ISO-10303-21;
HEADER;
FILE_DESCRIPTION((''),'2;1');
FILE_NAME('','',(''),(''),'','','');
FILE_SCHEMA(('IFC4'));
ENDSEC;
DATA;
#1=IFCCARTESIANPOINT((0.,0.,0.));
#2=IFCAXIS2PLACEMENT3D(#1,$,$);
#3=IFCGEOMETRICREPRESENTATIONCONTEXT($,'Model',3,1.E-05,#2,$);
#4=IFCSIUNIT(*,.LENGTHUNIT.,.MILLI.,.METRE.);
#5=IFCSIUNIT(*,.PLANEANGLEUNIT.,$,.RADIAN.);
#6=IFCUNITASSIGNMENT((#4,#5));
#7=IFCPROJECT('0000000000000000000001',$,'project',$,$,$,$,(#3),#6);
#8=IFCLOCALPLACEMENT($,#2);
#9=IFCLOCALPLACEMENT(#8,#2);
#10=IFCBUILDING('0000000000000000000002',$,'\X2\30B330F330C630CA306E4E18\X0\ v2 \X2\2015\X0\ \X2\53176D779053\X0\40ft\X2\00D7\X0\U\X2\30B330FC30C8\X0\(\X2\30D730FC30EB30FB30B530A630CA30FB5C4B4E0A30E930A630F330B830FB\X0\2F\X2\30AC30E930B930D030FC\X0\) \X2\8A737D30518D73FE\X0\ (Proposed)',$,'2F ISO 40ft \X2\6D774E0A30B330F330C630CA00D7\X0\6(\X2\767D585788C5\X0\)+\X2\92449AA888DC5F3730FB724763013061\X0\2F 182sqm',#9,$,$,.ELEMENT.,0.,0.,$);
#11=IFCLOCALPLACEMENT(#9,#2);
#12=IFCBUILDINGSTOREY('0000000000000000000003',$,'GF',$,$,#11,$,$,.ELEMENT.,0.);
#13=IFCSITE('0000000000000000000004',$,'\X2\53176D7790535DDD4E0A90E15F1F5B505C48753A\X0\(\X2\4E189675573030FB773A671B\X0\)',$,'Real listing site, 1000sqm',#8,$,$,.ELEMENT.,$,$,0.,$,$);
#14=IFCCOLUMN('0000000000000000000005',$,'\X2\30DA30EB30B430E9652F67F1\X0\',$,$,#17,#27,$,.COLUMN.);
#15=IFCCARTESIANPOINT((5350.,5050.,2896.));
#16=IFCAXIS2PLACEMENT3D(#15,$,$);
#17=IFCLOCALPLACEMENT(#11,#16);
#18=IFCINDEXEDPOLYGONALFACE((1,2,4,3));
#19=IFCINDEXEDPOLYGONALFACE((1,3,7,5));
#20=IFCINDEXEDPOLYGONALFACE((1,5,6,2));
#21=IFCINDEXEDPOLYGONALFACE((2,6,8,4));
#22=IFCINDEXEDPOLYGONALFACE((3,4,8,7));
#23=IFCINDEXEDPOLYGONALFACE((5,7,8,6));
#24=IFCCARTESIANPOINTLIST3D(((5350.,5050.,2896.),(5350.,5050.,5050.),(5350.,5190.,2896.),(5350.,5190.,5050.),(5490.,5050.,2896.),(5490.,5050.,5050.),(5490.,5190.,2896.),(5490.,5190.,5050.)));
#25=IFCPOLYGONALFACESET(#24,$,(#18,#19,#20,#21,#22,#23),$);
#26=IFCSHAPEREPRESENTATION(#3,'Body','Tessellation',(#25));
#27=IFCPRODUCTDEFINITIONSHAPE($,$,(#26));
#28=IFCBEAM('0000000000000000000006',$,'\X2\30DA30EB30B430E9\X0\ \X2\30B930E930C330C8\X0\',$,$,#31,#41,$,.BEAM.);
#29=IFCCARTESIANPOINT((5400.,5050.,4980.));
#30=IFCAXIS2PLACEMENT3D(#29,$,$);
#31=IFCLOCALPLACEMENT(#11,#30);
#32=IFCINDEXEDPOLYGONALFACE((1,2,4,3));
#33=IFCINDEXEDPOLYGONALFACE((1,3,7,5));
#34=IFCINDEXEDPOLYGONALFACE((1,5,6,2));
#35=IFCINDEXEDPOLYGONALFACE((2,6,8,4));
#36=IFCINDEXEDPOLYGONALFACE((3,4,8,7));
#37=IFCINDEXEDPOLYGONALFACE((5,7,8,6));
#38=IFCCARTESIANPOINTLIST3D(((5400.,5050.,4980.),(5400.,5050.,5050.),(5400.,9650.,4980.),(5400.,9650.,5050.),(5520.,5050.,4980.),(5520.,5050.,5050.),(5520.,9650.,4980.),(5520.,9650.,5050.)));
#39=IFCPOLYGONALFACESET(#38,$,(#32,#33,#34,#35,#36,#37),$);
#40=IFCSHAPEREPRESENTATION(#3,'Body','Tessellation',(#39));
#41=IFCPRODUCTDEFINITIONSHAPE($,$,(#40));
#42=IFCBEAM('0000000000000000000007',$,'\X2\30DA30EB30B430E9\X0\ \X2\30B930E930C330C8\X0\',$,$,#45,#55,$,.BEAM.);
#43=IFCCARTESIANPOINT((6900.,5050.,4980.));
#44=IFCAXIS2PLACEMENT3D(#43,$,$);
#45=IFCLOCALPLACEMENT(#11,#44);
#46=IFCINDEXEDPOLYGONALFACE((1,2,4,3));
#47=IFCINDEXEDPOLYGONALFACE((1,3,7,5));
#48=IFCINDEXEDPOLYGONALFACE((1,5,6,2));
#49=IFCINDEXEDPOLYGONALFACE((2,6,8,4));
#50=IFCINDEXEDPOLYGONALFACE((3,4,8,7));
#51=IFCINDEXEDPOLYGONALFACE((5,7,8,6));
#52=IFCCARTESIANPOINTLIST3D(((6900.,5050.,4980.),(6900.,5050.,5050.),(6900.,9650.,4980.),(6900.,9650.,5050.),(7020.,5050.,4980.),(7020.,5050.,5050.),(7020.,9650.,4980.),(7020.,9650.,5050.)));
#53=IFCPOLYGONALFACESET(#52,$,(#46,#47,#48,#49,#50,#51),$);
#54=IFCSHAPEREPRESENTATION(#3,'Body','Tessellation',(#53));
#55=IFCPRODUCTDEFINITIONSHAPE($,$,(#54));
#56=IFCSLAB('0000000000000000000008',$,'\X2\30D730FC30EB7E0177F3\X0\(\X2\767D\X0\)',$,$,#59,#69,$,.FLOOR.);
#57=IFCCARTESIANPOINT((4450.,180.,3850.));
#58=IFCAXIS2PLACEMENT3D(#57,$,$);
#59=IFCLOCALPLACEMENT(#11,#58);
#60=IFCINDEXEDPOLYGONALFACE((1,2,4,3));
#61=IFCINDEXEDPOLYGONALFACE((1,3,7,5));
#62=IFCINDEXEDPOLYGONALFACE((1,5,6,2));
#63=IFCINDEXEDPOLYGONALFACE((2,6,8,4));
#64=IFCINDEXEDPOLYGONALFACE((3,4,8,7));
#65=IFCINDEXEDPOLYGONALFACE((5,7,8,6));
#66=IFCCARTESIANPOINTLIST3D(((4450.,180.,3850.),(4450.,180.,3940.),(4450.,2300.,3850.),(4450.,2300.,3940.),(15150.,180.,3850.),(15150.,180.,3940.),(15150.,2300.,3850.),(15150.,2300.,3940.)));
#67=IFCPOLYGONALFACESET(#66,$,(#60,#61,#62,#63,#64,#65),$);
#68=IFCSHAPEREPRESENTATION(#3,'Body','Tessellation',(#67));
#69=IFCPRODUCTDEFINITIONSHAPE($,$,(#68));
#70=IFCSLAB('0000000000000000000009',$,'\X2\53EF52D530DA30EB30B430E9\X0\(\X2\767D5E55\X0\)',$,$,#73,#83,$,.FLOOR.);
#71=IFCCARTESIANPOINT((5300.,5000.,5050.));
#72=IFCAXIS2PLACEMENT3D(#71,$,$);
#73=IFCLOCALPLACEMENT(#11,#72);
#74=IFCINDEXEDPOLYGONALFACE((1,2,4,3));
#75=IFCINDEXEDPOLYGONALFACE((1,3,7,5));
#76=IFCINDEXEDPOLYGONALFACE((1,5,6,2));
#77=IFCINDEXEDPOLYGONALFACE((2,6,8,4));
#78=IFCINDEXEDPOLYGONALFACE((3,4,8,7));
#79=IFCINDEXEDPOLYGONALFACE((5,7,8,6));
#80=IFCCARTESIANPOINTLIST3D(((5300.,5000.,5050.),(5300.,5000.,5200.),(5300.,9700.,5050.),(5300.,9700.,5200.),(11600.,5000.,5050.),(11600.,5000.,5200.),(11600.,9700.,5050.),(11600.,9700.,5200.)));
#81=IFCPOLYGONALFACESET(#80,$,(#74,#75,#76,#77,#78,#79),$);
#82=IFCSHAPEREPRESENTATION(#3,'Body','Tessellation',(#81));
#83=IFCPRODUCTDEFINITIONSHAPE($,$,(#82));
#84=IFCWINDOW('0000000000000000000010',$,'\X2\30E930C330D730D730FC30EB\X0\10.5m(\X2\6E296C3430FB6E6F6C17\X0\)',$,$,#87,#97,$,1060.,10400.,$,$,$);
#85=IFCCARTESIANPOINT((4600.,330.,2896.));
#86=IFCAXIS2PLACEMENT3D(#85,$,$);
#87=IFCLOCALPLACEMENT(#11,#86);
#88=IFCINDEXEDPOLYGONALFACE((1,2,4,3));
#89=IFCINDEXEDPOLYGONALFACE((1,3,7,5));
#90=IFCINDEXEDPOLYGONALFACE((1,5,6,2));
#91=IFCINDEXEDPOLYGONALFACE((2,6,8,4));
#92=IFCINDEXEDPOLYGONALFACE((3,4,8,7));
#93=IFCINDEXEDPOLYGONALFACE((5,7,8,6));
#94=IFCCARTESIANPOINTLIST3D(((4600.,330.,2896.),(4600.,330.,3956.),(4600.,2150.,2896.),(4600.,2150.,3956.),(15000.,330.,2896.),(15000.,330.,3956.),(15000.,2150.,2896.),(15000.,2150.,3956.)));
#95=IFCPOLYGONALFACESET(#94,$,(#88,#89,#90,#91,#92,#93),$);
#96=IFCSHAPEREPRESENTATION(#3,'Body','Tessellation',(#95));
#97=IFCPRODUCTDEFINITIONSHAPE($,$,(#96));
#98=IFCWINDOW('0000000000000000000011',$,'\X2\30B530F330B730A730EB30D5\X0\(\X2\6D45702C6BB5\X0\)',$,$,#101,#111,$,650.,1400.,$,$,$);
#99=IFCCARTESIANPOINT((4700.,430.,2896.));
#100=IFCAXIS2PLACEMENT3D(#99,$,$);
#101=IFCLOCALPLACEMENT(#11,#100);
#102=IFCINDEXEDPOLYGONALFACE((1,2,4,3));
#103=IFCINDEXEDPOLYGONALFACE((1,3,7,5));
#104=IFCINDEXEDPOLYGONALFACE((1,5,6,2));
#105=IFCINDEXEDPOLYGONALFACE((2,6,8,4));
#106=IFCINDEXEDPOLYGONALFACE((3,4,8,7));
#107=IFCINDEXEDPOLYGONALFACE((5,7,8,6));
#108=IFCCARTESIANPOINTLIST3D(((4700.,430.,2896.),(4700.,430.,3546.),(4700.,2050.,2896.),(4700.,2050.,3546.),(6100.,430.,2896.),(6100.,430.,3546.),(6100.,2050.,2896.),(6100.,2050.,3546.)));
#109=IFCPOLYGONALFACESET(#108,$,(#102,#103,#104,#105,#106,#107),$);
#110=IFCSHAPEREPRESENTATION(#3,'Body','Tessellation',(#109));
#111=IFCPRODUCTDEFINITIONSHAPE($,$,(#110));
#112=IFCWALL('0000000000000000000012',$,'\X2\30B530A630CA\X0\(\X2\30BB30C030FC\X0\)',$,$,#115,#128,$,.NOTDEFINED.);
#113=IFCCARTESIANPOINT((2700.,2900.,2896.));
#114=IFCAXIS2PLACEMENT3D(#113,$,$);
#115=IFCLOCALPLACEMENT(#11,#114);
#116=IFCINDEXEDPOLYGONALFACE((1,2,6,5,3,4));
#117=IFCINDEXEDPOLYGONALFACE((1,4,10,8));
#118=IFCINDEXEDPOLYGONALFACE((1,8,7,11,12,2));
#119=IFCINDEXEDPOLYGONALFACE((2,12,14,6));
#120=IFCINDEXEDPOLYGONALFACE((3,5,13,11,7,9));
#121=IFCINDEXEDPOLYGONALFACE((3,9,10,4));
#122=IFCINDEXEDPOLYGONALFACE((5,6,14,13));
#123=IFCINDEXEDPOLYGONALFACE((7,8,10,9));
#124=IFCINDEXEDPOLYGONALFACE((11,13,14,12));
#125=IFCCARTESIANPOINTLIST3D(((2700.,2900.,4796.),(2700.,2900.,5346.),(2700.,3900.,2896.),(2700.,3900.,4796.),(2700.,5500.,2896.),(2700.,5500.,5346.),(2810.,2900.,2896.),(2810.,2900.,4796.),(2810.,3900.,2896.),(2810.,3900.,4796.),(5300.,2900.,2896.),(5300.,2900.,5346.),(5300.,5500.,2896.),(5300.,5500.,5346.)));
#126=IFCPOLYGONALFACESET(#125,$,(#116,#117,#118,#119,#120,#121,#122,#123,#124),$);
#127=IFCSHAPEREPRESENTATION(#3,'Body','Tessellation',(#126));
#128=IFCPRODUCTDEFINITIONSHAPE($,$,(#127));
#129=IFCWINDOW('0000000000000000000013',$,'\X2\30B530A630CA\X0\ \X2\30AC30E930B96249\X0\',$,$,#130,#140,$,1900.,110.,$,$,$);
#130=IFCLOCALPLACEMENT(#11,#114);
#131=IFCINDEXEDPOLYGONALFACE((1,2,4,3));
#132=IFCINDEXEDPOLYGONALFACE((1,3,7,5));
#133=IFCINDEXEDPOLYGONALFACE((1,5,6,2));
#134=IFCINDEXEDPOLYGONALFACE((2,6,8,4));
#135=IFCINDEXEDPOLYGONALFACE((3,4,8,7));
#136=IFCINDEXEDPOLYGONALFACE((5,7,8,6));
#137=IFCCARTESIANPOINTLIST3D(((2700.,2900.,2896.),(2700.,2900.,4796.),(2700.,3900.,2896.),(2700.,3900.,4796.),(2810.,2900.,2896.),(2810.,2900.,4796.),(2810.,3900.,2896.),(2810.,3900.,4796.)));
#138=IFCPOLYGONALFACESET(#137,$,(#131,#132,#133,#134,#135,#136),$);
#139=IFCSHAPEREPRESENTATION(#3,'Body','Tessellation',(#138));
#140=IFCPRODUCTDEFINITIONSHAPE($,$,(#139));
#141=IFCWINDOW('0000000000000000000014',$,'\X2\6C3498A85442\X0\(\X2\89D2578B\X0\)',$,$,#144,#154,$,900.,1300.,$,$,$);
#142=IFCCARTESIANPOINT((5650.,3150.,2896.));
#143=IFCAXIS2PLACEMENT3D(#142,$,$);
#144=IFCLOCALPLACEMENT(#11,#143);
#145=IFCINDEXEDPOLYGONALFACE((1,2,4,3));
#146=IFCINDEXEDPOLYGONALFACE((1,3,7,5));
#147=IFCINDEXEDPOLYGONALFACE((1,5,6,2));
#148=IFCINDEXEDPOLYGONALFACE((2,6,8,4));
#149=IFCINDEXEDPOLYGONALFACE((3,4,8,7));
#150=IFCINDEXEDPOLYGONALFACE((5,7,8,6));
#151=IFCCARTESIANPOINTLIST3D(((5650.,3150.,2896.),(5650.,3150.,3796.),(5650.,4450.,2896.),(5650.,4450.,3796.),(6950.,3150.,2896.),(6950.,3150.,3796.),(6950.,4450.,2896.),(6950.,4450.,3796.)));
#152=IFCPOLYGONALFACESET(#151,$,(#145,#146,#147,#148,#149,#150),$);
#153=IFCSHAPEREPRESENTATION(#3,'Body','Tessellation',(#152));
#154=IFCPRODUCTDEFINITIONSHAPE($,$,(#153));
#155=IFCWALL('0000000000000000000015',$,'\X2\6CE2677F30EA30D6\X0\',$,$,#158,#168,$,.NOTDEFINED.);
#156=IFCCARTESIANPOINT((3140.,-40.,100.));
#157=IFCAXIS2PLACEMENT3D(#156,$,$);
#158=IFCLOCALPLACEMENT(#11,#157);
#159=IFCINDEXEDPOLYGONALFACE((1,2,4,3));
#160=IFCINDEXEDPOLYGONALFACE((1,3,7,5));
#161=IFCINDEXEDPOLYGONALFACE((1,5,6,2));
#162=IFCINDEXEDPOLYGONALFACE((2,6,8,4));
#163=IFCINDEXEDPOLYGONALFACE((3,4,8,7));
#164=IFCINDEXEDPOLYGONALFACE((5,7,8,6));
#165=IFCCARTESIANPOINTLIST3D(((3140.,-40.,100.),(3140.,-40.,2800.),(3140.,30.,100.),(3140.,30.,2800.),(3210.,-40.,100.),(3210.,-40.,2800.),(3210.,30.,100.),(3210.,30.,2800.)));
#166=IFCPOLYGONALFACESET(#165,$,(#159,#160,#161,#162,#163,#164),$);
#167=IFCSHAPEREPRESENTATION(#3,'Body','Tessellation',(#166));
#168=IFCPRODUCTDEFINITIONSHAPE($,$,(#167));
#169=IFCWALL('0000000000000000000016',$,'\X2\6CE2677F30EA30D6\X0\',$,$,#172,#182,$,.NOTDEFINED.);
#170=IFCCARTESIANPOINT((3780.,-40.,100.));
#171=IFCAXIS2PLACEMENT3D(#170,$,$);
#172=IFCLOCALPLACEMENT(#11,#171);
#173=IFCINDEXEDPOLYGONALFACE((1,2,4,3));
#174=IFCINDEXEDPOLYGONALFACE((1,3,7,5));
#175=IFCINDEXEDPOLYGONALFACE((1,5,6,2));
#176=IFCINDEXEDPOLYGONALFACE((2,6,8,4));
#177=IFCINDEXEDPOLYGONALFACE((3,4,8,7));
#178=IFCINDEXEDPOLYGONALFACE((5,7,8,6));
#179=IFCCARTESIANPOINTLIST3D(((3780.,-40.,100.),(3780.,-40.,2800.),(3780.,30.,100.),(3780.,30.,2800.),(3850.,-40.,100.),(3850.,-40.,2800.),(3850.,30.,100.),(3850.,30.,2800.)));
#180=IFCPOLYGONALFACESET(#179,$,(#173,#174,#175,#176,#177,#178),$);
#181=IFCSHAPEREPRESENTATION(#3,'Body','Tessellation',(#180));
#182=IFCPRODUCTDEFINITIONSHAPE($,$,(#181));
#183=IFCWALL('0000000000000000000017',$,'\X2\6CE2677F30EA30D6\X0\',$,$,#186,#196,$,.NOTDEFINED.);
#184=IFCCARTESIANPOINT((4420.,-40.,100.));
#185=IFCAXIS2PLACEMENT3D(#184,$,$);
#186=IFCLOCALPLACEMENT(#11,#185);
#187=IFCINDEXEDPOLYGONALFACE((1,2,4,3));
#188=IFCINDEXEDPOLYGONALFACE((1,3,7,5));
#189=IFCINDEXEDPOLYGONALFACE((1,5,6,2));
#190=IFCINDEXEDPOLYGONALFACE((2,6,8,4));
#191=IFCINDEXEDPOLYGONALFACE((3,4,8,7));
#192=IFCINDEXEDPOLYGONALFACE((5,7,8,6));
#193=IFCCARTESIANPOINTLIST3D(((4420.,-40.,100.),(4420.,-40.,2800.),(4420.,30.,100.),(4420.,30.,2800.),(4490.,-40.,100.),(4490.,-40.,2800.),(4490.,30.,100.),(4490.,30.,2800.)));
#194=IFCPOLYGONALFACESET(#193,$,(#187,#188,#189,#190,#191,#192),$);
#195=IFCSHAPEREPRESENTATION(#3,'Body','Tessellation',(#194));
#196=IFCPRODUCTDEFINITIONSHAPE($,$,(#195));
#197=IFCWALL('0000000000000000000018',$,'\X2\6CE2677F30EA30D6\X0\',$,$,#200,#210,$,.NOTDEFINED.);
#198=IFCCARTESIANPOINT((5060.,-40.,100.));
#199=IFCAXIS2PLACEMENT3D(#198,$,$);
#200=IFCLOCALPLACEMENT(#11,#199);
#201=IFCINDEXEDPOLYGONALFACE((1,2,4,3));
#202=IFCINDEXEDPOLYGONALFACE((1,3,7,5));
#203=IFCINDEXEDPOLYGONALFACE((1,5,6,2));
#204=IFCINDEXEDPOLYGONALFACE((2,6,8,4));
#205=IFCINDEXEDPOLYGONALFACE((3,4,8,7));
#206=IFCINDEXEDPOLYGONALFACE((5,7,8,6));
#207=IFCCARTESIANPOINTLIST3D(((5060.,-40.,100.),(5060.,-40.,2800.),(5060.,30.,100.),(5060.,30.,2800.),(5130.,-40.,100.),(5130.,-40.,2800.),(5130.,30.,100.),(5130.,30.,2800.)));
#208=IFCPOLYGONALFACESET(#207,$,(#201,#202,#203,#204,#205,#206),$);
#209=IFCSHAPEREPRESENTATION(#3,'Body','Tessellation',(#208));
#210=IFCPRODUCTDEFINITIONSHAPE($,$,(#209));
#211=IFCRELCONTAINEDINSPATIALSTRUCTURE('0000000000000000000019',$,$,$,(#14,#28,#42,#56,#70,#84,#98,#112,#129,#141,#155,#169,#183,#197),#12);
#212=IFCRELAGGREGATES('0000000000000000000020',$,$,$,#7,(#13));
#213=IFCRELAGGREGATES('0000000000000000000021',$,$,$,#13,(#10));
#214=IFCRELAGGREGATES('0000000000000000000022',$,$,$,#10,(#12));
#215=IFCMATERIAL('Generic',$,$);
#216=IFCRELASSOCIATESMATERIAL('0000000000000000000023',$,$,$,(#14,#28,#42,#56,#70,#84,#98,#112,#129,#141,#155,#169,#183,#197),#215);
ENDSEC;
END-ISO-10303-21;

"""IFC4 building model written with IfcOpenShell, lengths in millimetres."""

from ifc_helpers import new_model, si_unit, frame, frame_2d, origin, place, context, project, spatial, rectangle, extrude, material, element, fill, save


model = new_model("IFC4")

# Units and contexts
model_context = context("Model", 3, precision=1e-05, world=origin())
ifc_project = project(units=[si_unit("LENGTHUNIT", "METRE", prefix="MILLI"), si_unit("PLANEANGLEUNIT", "RADIAN")], contexts=[model_context])

# Site, building, storey
site_placement = place(None, origin())
site = spatial("IfcSite", under=ifc_project, at=site_placement, Name="北海道川上郡弟子屈町(丘陵地・眺望)", ObjectType="Real listing site, 1000sqm", CompositionType="ELEMENT", RefElevation=0.0)
building_placement = place(site_placement, origin())
building = spatial("IfcBuilding", under=site, at=building_placement, Name="コンテナの丘 v2 ― 北海道40ft×Uコート(プール・サウナ・屋上ラウンジ・2Fガラスバー) 詳細再現 (Proposed)", ObjectType="2F ISO 40ft 海上コンテナ×6(白塗装)+鉄骨補強・片持ち2F 182sqm", CompositionType="ELEMENT", ElevationOfRefHeight=0.0, ElevationOfTerrain=0.0)
storey_placement = place(building_placement, origin())
storey = spatial("IfcBuildingStorey", under=building, at=storey_placement, Name="GF", CompositionType="ELEMENT", Elevation=0.0)

# Column
ifc_material = material(Name="Generic")
column_placement = place(storey_placement, frame((5350.0, 5050.0, 2896.0)))
element("IfcColumn", 1, at=column_placement, inside=storey, material=ifc_material, Name="ペルゴラ支柱", PredefinedType="COLUMN", context=model_context, shape_type="SweptSolid", body=[
    extrude(rectangle(XDim=140.0, YDim=140.0, at=frame_2d((70.0, 70.0))), frame((5350.0, 5050.0, 2896.0)), (0.0, 0.0, 1.0), 2154.0),
])

# Beams
beam_1_placement = place(storey_placement, frame((5400.0, 5050.0, 4980.0)))
element("IfcBeam", 2, at=beam_1_placement, inside=storey, material=ifc_material, Name="ペルゴラ スラット", PredefinedType="BEAM", context=model_context, shape_type="SweptSolid", body=[
    extrude(rectangle(XDim=120.0, YDim=4600.0, at=frame_2d((60.0, 2300.0))), frame((5400.0, 5050.0, 4980.0)), (0.0, 0.0, 1.0), 70.0),
])
beam_2_placement = place(storey_placement, frame((6900.0, 5050.0, 4980.0)))
element("IfcBeam", 3, at=beam_2_placement, inside=storey, material=ifc_material, Name="ペルゴラ スラット", PredefinedType="BEAM", context=model_context, shape_type="SweptSolid", body=[
    extrude(rectangle(XDim=120.0, YDim=4600.0, at=frame_2d((60.0, 2300.0))), frame((6900.0, 5050.0, 4980.0)), (0.0, 0.0, 1.0), 70.0),
])

# Slabs
slab_1_placement = place(storey_placement, frame((4450.0, 180.0, 3850.0)))
element("IfcSlab", 4, at=slab_1_placement, inside=storey, material=ifc_material, Name="プール縁石(白)", PredefinedType="FLOOR", context=model_context, shape_type="SweptSolid", body=[
    extrude(rectangle(XDim=10700.0, YDim=2120.0, at=frame_2d((5350.0, 1060.0))), frame((4450.0, 180.0, 3850.0)), (0.0, 0.0, 1.0), 90.0),
])
slab_2_placement = place(storey_placement, frame((5300.0, 5000.0, 5050.0)))
element("IfcSlab", 5, at=slab_2_placement, inside=storey, material=ifc_material, Name="可動ペルゴラ(白幕)", PredefinedType="FLOOR", context=model_context, shape_type="SweptSolid", body=[
    extrude(rectangle(XDim=6300.0, YDim=4700.0, at=frame_2d((3150.0, 2350.0))), frame((5300.0, 5000.0, 5050.0)), (0.0, 0.0, 1.0), 150.0),
])

# Windows
window_1_placement = place(storey_placement, frame((4600.0, 330.0, 2896.0)))
element("IfcWindow", 6, at=window_1_placement, inside=storey, material=ifc_material, Name="ラッププール10.5m(温水・湯気)", OverallHeight=1060.0, OverallWidth=10400.0, context=model_context, shape_type="SweptSolid", body=[
    extrude(rectangle(XDim=10400.0, YDim=1820.0, at=frame_2d((5200.0, 910.0))), frame((4600.0, 330.0, 2896.0)), (0.0, 0.0, 1.0), 1060.0),
])
window_2_placement = place(storey_placement, frame((4700.0, 430.0, 2896.0)))
element("IfcWindow", 7, at=window_2_placement, inside=storey, material=ifc_material, Name="サンシェルフ(浅瀬段)", OverallHeight=650.0, OverallWidth=1400.0, context=model_context, shape_type="SweptSolid", body=[
    extrude(rectangle(XDim=1400.0, YDim=1620.0, at=frame_2d((700.0, 810.0))), frame((4700.0, 430.0, 2896.0)), (0.0, 0.0, 1.0), 650.0),
])

# Wall, opening, window
wall_1_placement = place(storey_placement, frame((2700.0, 2900.0, 2896.0)))
wall_1 = element("IfcWall", 8, at=wall_1_placement, inside=storey, material=ifc_material, Name="サウナ(セダー)", PredefinedType="NOTDEFINED", context=model_context, shape_type="SweptSolid", body=[
    extrude(rectangle(XDim=2600.0, YDim=2600.0, at=frame_2d((1300.0, 1300.0))), frame((2700.0, 2900.0, 2896.0)), (0.0, 0.0, 1.0), 2450.0),
])
opening_placement = place(storey_placement, frame((2700.0, 2900.0, 2896.0)))
opening = element("IfcOpeningElement", 9, at=opening_placement, cuts=wall_1, PredefinedType="NOTDEFINED", context=model_context, shape_type="SweptSolid", body=[
    extrude(rectangle(XDim=110.0, YDim=1000.0, at=frame_2d((55.0, 500.0))), frame((2700.0, 2900.0, 2896.0)), (0.0, 0.0, 1.0), 1900.0),
])
window_3_placement = place(storey_placement, frame((2700.0, 2900.0, 2896.0)))
window_3 = element("IfcWindow", 10, at=window_3_placement, inside=storey, material=ifc_material, Name="サウナ ガラス扉", OverallHeight=1900.0, OverallWidth=110.0, context=model_context, shape_type="SweptSolid", body=[
    extrude(rectangle(XDim=110.0, YDim=1000.0, at=frame_2d((55.0, 500.0))), frame((2700.0, 2900.0, 2896.0)), (0.0, 0.0, 1.0), 1900.0),
])
fill(opening, window_3)

# Window
window_4_placement = place(storey_placement, frame((5650.0, 3150.0, 2896.0)))
element("IfcWindow", 11, at=window_4_placement, inside=storey, material=ifc_material, Name="水風呂(角型)", OverallHeight=900.0, OverallWidth=1300.0, context=model_context, shape_type="SweptSolid", body=[
    extrude(rectangle(XDim=1300.0, YDim=1300.0, at=frame_2d((650.0, 650.0))), frame((5650.0, 3150.0, 2896.0)), (0.0, 0.0, 1.0), 900.0),
])

# Walls
wall_2_placement = place(storey_placement, frame((3140.0, -40.0, 100.0)))
element("IfcWall", 12, at=wall_2_placement, inside=storey, material=ifc_material, Name="波板リブ", PredefinedType="NOTDEFINED", context=model_context, shape_type="SweptSolid", body=[
    extrude(rectangle(XDim=70.0, YDim=70.0, at=frame_2d((35.0, 35.0))), frame((3140.0, -40.0, 100.0)), (0.0, 0.0, 1.0), 2700.0),
])
wall_3_placement = place(storey_placement, frame((3780.0, -40.0, 100.0)))
element("IfcWall", 13, at=wall_3_placement, inside=storey, material=ifc_material, Name="波板リブ", PredefinedType="NOTDEFINED", context=model_context, shape_type="SweptSolid", body=[
    extrude(rectangle(XDim=70.0, YDim=70.0, at=frame_2d((35.0, 35.0))), frame((3780.0, -40.0, 100.0)), (0.0, 0.0, 1.0), 2700.0),
])
wall_4_placement = place(storey_placement, frame((4420.0, -40.0, 100.0)))
element("IfcWall", 14, at=wall_4_placement, inside=storey, material=ifc_material, Name="波板リブ", PredefinedType="NOTDEFINED", context=model_context, shape_type="SweptSolid", body=[
    extrude(rectangle(XDim=70.0, YDim=70.0, at=frame_2d((35.0, 35.0))), frame((4420.0, -40.0, 100.0)), (0.0, 0.0, 1.0), 2700.0),
])
wall_5_placement = place(storey_placement, frame((5060.0, -40.0, 100.0)))
element("IfcWall", 15, at=wall_5_placement, inside=storey, material=ifc_material, Name="波板リブ", PredefinedType="NOTDEFINED", context=model_context, shape_type="SweptSolid", body=[
    extrude(rectangle(XDim=70.0, YDim=70.0, at=frame_2d((35.0, 35.0))), frame((5060.0, -40.0, 100.0)), (0.0, 0.0, 1.0), 2700.0),
])

save(model, "model.ifc")
